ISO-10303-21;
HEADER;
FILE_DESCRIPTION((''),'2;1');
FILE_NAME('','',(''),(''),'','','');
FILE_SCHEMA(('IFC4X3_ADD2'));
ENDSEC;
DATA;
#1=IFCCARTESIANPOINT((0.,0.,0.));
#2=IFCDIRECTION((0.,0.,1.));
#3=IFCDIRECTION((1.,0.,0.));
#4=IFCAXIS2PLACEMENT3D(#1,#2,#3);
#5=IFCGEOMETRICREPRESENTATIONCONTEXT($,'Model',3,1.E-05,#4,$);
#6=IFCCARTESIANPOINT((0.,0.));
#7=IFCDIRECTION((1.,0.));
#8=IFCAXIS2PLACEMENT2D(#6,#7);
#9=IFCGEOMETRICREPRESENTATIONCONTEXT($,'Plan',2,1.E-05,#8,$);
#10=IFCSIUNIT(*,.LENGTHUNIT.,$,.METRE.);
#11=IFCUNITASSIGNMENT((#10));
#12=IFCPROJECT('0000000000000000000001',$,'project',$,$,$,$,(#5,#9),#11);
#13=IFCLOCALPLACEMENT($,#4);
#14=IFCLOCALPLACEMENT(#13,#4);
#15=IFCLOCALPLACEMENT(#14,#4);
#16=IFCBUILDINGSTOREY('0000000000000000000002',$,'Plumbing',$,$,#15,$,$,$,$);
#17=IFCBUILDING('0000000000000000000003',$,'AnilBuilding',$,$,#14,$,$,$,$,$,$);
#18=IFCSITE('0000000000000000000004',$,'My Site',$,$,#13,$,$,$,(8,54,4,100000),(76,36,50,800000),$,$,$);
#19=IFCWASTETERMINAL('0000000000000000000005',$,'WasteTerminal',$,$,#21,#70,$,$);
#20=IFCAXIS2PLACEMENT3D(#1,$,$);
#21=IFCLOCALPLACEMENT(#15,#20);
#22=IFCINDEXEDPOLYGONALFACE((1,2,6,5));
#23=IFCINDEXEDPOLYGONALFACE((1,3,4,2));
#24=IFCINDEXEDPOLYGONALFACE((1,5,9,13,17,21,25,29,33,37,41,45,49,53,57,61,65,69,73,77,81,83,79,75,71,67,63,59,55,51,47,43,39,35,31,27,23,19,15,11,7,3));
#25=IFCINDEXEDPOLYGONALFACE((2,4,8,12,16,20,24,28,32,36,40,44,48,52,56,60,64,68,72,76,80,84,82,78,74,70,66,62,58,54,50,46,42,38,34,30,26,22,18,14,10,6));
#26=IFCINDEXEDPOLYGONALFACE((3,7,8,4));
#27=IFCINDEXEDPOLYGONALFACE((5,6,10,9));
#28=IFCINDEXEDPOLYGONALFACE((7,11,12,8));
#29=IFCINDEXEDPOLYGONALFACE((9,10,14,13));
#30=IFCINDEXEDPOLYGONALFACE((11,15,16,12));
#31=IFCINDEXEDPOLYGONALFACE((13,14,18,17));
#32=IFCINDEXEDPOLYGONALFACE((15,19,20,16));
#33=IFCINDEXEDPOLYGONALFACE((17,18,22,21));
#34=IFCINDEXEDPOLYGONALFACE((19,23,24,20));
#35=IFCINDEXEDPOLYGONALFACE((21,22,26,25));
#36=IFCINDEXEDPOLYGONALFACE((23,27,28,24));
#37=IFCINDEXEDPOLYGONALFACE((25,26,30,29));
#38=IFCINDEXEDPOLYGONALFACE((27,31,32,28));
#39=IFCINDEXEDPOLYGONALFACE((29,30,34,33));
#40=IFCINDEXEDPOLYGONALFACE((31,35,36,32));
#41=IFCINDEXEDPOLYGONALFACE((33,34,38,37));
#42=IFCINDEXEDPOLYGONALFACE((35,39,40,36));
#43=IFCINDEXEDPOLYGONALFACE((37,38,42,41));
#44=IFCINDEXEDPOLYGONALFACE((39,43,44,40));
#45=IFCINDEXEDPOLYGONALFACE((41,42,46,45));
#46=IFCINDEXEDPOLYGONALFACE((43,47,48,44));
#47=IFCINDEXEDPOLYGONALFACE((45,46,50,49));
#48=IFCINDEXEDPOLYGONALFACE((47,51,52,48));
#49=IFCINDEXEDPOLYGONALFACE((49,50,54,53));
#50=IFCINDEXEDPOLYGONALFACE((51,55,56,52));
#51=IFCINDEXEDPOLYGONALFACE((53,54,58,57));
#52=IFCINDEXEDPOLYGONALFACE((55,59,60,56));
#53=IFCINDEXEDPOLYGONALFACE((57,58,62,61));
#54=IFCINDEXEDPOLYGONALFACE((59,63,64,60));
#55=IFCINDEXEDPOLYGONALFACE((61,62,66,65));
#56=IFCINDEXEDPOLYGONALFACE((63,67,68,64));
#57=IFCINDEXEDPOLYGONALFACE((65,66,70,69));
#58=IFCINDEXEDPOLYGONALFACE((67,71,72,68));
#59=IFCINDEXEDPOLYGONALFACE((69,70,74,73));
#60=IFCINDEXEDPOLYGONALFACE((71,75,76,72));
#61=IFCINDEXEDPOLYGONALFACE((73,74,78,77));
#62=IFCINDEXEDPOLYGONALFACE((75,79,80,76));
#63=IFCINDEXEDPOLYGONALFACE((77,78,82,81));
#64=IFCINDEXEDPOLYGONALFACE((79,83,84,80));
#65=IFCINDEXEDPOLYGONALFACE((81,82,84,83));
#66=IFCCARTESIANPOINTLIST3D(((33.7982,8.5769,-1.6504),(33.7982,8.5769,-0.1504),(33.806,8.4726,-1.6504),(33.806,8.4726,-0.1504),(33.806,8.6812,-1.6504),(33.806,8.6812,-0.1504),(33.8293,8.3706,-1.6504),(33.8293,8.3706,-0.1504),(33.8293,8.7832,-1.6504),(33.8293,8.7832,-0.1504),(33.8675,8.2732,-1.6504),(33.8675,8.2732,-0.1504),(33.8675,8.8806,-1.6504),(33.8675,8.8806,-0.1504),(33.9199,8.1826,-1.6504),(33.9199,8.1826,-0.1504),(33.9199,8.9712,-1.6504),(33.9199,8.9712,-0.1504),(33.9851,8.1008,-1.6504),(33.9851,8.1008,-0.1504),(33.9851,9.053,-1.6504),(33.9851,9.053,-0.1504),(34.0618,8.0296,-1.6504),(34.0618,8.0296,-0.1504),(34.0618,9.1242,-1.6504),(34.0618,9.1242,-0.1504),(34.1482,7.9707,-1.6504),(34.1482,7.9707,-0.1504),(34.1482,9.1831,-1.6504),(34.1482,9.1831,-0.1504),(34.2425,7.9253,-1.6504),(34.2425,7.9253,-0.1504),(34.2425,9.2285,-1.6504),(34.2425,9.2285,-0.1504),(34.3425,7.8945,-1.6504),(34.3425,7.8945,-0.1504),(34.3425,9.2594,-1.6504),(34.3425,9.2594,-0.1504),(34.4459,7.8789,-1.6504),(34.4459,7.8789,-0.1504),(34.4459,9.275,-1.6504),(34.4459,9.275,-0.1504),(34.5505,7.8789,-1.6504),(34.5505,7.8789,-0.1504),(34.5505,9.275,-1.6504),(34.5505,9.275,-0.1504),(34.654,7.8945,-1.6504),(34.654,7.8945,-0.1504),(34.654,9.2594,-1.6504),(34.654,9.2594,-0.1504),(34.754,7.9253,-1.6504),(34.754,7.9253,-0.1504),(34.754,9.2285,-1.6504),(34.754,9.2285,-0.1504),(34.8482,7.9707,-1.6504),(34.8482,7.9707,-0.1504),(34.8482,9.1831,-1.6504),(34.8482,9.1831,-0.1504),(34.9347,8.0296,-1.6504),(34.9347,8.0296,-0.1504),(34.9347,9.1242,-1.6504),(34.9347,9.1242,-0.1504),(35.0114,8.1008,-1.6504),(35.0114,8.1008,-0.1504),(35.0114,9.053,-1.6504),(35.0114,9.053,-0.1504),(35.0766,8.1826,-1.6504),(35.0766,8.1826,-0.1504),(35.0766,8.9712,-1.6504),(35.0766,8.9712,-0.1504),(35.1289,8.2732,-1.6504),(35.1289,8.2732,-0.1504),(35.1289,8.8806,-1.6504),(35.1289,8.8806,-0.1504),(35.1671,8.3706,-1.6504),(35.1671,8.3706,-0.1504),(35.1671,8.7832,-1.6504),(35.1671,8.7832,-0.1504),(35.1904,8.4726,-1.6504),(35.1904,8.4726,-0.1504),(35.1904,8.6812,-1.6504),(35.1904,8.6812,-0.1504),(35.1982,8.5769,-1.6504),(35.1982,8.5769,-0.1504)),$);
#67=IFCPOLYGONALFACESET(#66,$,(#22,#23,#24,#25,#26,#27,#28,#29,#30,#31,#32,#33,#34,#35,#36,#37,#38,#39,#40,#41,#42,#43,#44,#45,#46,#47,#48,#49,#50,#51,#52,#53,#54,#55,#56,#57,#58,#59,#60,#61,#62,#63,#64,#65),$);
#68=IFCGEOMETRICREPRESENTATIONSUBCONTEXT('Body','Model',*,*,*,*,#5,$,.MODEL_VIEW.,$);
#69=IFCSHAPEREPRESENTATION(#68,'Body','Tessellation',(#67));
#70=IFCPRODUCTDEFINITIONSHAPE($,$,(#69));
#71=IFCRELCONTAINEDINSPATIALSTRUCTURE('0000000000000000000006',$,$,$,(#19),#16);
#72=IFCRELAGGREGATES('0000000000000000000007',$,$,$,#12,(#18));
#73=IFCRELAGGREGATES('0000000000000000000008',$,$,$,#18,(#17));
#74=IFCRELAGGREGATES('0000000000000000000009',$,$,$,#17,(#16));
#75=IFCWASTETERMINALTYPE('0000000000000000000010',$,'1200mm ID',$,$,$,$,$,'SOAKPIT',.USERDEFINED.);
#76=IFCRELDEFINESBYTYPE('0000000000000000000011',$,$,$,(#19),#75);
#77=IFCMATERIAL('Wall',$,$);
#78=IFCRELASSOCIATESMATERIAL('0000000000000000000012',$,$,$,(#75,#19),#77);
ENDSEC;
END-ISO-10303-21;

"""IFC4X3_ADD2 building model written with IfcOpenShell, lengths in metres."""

from ifc_helpers import new_model, si_unit, frame, origin_with_axes, origin_2d_with_axis, place, context, subcontext, project, spatial, circle, extrude, material, material_profile, profile_set, profile_usage, type_object, element, save


model = new_model("IFC4X3_ADD2")

# Units and contexts
model_context = context("Model", 3, precision=1e-05, world=origin_with_axes())
plan_context = context("Plan", 2, precision=1e-05, world=origin_2d_with_axis())
body_context = subcontext(model_context, "Body", "Model", "MODEL_VIEW")
ifc_project = project(units=[si_unit("LENGTHUNIT", "METRE")], contexts=[model_context, plan_context])

# Site, building, storey
site_placement = place(None, origin_with_axes())
site = spatial("IfcSite", under=ifc_project, at=site_placement, Name="My Site", RefLatitude=(8, 54, 4, 100000), RefLongitude=(76, 36, 50, 800000))
building_placement = place(site_placement, origin_with_axes())
building = spatial("IfcBuilding", under=site, at=building_placement, Name="AnilBuilding")
storey_placement = place(building_placement, origin_with_axes())
storey = spatial("IfcBuildingStorey", under=building, at=storey_placement, Name="Plumbing")

# Shared definitions
ifc_material_1 = material(Name="Wall")

# Waste terminal
ifc_material_profile_1 = material_profile(ifc_material_1, circle(Radius=0.7))
ifc_profile_set_1 = profile_set([ifc_material_profile_1])
waste_terminal_type = type_object("IfcWasteTerminalType", Name="1200mm ID", ElementType="SOAKPIT", PredefinedType="USERDEFINED", material=ifc_profile_set_1)
ifc_profile_usage_1 = profile_usage(ifc_profile_set_1, cardinal=5)
waste_terminal_1_placement = place(storey_placement, frame((34.4982, 8.5769, -0.1504), z_axis=(0.0, 0.0, -1.0), x_axis=(-1.0, 0.0, 0.0)))
element("IfcWasteTerminal", 1, at=waste_terminal_1_placement, inside=storey, type_object=waste_terminal_type, material=ifc_profile_usage_1, Name="WasteTerminal", context=body_context, shape_type="SweptSolid", body=[
    extrude(circle(Radius=0.7), origin_with_axes(), (0.0, 0.0, 1.0), 1.5),
])

save(model, "model.ifc")
